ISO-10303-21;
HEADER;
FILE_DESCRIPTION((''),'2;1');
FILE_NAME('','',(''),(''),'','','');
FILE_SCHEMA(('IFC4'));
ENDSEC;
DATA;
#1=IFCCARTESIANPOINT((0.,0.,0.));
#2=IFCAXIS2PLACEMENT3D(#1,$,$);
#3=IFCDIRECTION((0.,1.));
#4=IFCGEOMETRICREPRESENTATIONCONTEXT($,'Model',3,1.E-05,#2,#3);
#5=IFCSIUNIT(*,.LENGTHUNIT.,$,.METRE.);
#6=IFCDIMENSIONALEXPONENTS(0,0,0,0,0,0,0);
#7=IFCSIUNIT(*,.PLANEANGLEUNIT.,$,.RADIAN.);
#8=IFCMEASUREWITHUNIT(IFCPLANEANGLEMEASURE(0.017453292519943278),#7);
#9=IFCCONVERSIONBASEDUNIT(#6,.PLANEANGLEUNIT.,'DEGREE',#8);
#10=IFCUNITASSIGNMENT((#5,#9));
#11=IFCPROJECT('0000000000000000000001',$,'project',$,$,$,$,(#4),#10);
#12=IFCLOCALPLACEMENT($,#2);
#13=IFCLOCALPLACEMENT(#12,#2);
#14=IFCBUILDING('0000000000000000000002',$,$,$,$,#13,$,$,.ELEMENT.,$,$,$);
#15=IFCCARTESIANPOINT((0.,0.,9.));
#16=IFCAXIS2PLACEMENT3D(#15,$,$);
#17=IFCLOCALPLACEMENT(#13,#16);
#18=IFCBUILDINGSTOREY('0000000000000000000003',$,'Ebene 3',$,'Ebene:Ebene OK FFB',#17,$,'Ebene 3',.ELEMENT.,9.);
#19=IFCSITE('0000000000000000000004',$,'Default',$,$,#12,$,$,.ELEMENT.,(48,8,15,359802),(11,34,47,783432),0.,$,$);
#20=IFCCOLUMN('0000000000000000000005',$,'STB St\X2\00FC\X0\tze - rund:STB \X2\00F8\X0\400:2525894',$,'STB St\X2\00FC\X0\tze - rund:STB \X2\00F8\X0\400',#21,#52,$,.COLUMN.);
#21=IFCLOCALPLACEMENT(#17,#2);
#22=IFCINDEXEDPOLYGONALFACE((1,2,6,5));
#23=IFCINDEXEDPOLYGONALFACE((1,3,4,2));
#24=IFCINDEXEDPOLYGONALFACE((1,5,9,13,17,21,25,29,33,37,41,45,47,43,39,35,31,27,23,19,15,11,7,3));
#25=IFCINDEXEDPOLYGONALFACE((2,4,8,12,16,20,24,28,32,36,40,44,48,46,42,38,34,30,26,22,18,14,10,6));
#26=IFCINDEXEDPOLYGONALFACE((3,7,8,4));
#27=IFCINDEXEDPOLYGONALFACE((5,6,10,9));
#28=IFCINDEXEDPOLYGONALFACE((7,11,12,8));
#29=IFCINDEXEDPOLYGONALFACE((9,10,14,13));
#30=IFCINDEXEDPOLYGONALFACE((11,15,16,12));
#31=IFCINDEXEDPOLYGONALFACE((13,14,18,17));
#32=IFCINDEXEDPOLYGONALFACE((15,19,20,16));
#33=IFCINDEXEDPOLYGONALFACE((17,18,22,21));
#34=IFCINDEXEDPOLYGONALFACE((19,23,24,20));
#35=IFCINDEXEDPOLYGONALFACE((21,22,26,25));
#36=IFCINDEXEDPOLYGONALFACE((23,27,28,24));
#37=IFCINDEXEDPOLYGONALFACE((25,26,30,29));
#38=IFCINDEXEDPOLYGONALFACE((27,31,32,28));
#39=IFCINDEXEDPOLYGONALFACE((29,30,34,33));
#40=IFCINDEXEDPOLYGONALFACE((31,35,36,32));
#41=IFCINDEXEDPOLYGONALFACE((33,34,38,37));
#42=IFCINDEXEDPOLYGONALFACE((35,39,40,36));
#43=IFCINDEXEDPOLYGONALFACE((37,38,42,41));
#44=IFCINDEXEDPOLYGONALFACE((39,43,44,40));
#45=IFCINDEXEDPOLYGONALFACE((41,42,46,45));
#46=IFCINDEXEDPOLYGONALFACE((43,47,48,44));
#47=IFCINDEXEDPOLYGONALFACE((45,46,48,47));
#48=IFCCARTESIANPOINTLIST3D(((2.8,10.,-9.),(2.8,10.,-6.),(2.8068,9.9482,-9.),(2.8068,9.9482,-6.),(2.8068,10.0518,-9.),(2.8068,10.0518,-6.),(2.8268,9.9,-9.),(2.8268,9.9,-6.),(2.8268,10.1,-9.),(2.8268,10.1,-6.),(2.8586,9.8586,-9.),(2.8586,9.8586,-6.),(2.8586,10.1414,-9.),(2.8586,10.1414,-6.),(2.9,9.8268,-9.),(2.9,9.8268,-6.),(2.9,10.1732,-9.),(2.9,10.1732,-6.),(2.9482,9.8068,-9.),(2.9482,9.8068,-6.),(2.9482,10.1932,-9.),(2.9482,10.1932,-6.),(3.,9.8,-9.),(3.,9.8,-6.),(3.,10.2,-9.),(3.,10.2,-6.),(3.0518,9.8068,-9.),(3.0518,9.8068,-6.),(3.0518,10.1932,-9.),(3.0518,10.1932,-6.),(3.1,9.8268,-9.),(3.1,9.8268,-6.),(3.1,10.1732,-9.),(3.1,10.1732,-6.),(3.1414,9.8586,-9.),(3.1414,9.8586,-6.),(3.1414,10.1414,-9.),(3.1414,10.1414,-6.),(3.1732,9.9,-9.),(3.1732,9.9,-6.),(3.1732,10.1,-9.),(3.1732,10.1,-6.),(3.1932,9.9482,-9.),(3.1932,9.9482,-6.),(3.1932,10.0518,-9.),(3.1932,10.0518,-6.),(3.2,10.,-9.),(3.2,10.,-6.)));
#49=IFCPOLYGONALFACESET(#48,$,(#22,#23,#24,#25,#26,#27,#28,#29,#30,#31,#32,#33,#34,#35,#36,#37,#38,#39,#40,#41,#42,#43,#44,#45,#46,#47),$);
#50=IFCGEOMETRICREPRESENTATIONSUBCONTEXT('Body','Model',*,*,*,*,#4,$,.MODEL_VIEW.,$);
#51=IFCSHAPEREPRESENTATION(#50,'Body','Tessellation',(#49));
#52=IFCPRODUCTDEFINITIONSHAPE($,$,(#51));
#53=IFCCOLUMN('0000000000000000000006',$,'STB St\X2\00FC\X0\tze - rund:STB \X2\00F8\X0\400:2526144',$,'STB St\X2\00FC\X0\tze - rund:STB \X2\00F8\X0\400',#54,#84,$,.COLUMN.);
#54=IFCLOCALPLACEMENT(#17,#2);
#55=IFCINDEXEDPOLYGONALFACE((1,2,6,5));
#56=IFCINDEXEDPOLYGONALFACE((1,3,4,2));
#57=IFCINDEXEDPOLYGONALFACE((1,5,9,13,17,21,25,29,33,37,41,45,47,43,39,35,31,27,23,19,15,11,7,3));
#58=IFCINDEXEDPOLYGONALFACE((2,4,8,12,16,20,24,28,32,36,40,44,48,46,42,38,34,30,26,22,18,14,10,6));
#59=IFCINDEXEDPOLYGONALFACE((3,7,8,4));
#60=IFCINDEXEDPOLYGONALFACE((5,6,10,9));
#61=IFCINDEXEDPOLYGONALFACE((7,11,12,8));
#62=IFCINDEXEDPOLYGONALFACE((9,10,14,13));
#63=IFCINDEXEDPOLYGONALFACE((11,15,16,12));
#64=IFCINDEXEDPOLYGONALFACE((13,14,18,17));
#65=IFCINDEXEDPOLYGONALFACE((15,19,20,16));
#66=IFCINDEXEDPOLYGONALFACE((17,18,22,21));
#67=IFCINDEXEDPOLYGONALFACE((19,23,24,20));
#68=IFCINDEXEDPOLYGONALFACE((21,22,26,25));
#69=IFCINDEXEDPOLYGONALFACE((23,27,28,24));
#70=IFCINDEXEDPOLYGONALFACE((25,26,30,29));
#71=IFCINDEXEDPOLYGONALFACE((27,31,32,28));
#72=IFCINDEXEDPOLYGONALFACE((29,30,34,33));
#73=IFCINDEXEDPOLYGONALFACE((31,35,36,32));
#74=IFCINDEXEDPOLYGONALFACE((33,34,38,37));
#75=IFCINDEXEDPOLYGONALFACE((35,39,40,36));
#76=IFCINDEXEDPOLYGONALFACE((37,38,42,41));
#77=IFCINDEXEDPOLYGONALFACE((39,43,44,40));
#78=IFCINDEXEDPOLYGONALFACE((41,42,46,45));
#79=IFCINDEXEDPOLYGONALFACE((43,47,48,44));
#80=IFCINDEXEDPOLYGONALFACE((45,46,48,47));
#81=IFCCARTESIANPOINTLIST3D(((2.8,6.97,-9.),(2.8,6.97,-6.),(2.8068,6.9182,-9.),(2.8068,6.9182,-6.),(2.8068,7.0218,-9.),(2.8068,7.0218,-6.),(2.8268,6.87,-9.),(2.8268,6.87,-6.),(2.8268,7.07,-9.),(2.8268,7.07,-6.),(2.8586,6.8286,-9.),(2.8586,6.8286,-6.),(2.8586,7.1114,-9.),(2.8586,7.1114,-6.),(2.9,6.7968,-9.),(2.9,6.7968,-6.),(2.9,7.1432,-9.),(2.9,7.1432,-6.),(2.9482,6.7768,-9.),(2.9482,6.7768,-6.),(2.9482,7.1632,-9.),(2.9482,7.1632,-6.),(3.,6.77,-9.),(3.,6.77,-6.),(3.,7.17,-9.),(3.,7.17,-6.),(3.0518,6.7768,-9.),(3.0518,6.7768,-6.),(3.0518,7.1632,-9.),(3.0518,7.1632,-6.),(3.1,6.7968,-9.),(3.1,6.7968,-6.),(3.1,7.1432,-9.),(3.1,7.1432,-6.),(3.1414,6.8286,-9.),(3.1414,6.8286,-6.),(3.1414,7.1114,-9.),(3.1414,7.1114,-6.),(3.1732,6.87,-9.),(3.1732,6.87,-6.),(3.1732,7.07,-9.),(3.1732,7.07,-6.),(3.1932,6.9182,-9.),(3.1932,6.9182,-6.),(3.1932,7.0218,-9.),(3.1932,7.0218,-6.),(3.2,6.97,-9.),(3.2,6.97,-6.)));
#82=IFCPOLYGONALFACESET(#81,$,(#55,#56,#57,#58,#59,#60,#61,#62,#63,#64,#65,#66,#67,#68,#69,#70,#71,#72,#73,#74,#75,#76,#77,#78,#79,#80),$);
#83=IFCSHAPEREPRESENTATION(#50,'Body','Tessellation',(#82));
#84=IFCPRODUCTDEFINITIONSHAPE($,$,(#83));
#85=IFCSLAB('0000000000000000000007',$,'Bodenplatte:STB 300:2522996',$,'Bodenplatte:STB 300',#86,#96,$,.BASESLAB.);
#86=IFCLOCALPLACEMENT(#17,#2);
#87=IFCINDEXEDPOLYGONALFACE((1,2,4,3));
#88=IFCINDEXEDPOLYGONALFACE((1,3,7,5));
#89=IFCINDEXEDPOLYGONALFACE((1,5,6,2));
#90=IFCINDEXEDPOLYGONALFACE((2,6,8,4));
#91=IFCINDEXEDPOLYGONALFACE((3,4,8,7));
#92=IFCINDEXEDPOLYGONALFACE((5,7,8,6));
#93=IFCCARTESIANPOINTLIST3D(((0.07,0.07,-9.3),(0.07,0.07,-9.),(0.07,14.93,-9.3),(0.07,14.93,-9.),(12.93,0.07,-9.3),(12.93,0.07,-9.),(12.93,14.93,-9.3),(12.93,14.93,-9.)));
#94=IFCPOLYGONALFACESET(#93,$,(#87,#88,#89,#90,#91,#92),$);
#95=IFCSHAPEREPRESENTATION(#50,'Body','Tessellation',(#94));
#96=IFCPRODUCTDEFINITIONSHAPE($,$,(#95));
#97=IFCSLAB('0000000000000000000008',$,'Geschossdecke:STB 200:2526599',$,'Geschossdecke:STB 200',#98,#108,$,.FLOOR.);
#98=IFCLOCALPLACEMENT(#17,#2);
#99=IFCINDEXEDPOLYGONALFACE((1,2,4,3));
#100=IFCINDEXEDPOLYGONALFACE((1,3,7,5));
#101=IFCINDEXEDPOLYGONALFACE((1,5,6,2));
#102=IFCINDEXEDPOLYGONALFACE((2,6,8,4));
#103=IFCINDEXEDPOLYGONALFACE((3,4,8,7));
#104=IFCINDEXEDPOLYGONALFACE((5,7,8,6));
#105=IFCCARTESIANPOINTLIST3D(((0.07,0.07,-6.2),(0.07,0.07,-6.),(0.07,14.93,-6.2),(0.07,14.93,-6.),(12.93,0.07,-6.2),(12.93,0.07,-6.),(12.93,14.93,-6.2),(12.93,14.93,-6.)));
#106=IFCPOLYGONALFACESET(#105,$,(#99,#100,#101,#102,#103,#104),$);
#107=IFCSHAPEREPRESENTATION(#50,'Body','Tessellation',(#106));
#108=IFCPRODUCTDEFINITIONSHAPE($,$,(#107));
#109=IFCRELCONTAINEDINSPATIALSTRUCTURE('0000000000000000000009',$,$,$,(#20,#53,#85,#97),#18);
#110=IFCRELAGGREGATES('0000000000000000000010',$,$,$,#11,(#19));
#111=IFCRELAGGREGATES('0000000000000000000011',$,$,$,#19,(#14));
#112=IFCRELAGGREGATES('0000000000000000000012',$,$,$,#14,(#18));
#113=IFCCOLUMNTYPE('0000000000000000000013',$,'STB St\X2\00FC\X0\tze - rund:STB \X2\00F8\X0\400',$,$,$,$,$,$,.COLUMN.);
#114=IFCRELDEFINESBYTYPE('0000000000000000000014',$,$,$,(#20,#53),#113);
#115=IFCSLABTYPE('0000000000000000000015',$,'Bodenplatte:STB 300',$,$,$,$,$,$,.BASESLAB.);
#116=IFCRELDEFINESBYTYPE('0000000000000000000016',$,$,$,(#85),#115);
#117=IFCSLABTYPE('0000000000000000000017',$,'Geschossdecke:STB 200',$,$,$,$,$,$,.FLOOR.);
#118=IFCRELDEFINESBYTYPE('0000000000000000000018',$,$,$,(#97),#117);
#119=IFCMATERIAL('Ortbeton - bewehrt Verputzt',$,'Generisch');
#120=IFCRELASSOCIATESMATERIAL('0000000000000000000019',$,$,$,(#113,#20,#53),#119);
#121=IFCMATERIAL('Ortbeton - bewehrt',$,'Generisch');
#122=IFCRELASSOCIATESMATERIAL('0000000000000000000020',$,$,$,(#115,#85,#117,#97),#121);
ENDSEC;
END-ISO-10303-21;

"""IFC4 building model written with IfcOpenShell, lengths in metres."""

from ifc_helpers import new_model, entity, si_unit, converted_unit, direction, frame, origin, place, context, subcontext, project, spatial, arc, indexed_curve, outline, extrude, source, transform, mapped, material, type_object, type_shapes, element, save


model = new_model("IFC4")

# Units and contexts
model_context = context("Model", 3, precision=1e-05, world=origin(), true_north=direction((0.0, 1.0)))
body_context = subcontext(model_context, "Body", "Model", "MODEL_VIEW")
ifc_project = project(units=[si_unit("LENGTHUNIT", "METRE"), converted_unit("PLANEANGLEUNIT", "DEGREE", entity("IfcPlaneAngleMeasure", 0.017453292519943278), si_unit("PLANEANGLEUNIT", "RADIAN"), dimensions=[0, 0, 0, 0, 0, 0, 0])], contexts=[model_context])

# Site, building, storey
site_placement = place(None, origin())
site = spatial("IfcSite", under=ifc_project, at=site_placement, Name="Default", CompositionType="ELEMENT", RefLatitude=(48, 8, 15, 359802), RefLongitude=(11, 34, 47, 783432), RefElevation=0.0)
building_placement = place(site_placement, origin())
building = spatial("IfcBuilding", under=site, at=building_placement, CompositionType="ELEMENT")
storey_placement = place(building_placement, frame((0.0, 0.0, 9.0)))
storey = spatial("IfcBuildingStorey", under=building, at=storey_placement, Name="Ebene 3", ObjectType="Ebene:Ebene OK FFB", LongName="Ebene 3", CompositionType="ELEMENT", Elevation=9.0)

# Columns
ifc_material_1 = material(Name="Ortbeton - bewehrt Verputzt", Category="Generisch")
column_type = type_object("IfcColumnType", Name="STB Stütze - rund:STB ø400", PredefinedType="COLUMN", material=ifc_material_1)
shared_shape = source(origin(), body_context, "Body", "SweptSolid", [
    extrude(outline(indexed_curve([(-0.2, 0.0), (0.0, -0.2), (0.2, 0.0), (0.0, 0.2)], segments=[arc(1, 2, 3), arc(3, 4, 1)], self_intersect=False)), origin(), (0.0, 0.0, 1.0), 3.0),
])
type_shapes(column_type, [shared_shape])
for number, where, name in (
    (1, (3.0, 10.0, -9.0), "STB Stütze - rund:STB ø400:2525894"),
    (2, (3.0, 6.97, -9.0), "STB Stütze - rund:STB ø400:2526144"),
):
    element("IfcColumn", number, at=place(storey_placement, frame(where)), inside=storey, type_object=column_type, material=ifc_material_1, Name=name, ObjectType="STB Stütze - rund:STB ø400", PredefinedType="COLUMN", context=body_context, shape_type="MappedRepresentation", body=[
        mapped(shared_shape, transform((0.0, 0.0, 0.0), scale=1.0)),
    ])

# Slabs
ifc_material_2 = material(Name="Ortbeton - bewehrt", Category="Generisch")
slab_type_1 = type_object("IfcSlabType", Name="Bodenplatte:STB 300", PredefinedType="BASESLAB", material=ifc_material_2)
slab_1_placement = place(storey_placement, origin())
element("IfcSlab", 3, at=slab_1_placement, inside=storey, type_object=slab_type_1, material=ifc_material_2, Name="Bodenplatte:STB 300:2522996", ObjectType="Bodenplatte:STB 300", PredefinedType="BASESLAB", context=body_context, shape_type="SweptSolid", body=[
    extrude(outline(indexed_curve([(-7.43, -6.43), (7.43, -6.43), (7.43, 6.43), (-7.43, 6.43), (-7.43, -6.43)], self_intersect=False)), frame((6.5, 7.5, -9.0), z_axis=(0.0, 0.0, -1.0), x_axis=(0.0, 1.0, 0.0)), (0.0, 0.0, 1.0), 0.3),
])
slab_type_2 = type_object("IfcSlabType", Name="Geschossdecke:STB 200", PredefinedType="FLOOR", material=ifc_material_2)
slab_2_placement = place(storey_placement, origin())
element("IfcSlab", 4, at=slab_2_placement, inside=storey, type_object=slab_type_2, material=ifc_material_2, Name="Geschossdecke:STB 200:2526599", ObjectType="Geschossdecke:STB 200", PredefinedType="FLOOR", context=body_context, shape_type="SweptSolid", body=[
    extrude(outline(indexed_curve([(-7.43, -6.43), (7.43, -6.43), (7.43, 6.43), (-7.43, 6.43), (-7.43, -6.43)], self_intersect=False)), frame((6.5, 7.5, -6.0), z_axis=(0.0, 0.0, -1.0), x_axis=(0.0, 1.0, 0.0)), (0.0, 0.0, 1.0), 0.2),
])

save(model, "model.ifc")
